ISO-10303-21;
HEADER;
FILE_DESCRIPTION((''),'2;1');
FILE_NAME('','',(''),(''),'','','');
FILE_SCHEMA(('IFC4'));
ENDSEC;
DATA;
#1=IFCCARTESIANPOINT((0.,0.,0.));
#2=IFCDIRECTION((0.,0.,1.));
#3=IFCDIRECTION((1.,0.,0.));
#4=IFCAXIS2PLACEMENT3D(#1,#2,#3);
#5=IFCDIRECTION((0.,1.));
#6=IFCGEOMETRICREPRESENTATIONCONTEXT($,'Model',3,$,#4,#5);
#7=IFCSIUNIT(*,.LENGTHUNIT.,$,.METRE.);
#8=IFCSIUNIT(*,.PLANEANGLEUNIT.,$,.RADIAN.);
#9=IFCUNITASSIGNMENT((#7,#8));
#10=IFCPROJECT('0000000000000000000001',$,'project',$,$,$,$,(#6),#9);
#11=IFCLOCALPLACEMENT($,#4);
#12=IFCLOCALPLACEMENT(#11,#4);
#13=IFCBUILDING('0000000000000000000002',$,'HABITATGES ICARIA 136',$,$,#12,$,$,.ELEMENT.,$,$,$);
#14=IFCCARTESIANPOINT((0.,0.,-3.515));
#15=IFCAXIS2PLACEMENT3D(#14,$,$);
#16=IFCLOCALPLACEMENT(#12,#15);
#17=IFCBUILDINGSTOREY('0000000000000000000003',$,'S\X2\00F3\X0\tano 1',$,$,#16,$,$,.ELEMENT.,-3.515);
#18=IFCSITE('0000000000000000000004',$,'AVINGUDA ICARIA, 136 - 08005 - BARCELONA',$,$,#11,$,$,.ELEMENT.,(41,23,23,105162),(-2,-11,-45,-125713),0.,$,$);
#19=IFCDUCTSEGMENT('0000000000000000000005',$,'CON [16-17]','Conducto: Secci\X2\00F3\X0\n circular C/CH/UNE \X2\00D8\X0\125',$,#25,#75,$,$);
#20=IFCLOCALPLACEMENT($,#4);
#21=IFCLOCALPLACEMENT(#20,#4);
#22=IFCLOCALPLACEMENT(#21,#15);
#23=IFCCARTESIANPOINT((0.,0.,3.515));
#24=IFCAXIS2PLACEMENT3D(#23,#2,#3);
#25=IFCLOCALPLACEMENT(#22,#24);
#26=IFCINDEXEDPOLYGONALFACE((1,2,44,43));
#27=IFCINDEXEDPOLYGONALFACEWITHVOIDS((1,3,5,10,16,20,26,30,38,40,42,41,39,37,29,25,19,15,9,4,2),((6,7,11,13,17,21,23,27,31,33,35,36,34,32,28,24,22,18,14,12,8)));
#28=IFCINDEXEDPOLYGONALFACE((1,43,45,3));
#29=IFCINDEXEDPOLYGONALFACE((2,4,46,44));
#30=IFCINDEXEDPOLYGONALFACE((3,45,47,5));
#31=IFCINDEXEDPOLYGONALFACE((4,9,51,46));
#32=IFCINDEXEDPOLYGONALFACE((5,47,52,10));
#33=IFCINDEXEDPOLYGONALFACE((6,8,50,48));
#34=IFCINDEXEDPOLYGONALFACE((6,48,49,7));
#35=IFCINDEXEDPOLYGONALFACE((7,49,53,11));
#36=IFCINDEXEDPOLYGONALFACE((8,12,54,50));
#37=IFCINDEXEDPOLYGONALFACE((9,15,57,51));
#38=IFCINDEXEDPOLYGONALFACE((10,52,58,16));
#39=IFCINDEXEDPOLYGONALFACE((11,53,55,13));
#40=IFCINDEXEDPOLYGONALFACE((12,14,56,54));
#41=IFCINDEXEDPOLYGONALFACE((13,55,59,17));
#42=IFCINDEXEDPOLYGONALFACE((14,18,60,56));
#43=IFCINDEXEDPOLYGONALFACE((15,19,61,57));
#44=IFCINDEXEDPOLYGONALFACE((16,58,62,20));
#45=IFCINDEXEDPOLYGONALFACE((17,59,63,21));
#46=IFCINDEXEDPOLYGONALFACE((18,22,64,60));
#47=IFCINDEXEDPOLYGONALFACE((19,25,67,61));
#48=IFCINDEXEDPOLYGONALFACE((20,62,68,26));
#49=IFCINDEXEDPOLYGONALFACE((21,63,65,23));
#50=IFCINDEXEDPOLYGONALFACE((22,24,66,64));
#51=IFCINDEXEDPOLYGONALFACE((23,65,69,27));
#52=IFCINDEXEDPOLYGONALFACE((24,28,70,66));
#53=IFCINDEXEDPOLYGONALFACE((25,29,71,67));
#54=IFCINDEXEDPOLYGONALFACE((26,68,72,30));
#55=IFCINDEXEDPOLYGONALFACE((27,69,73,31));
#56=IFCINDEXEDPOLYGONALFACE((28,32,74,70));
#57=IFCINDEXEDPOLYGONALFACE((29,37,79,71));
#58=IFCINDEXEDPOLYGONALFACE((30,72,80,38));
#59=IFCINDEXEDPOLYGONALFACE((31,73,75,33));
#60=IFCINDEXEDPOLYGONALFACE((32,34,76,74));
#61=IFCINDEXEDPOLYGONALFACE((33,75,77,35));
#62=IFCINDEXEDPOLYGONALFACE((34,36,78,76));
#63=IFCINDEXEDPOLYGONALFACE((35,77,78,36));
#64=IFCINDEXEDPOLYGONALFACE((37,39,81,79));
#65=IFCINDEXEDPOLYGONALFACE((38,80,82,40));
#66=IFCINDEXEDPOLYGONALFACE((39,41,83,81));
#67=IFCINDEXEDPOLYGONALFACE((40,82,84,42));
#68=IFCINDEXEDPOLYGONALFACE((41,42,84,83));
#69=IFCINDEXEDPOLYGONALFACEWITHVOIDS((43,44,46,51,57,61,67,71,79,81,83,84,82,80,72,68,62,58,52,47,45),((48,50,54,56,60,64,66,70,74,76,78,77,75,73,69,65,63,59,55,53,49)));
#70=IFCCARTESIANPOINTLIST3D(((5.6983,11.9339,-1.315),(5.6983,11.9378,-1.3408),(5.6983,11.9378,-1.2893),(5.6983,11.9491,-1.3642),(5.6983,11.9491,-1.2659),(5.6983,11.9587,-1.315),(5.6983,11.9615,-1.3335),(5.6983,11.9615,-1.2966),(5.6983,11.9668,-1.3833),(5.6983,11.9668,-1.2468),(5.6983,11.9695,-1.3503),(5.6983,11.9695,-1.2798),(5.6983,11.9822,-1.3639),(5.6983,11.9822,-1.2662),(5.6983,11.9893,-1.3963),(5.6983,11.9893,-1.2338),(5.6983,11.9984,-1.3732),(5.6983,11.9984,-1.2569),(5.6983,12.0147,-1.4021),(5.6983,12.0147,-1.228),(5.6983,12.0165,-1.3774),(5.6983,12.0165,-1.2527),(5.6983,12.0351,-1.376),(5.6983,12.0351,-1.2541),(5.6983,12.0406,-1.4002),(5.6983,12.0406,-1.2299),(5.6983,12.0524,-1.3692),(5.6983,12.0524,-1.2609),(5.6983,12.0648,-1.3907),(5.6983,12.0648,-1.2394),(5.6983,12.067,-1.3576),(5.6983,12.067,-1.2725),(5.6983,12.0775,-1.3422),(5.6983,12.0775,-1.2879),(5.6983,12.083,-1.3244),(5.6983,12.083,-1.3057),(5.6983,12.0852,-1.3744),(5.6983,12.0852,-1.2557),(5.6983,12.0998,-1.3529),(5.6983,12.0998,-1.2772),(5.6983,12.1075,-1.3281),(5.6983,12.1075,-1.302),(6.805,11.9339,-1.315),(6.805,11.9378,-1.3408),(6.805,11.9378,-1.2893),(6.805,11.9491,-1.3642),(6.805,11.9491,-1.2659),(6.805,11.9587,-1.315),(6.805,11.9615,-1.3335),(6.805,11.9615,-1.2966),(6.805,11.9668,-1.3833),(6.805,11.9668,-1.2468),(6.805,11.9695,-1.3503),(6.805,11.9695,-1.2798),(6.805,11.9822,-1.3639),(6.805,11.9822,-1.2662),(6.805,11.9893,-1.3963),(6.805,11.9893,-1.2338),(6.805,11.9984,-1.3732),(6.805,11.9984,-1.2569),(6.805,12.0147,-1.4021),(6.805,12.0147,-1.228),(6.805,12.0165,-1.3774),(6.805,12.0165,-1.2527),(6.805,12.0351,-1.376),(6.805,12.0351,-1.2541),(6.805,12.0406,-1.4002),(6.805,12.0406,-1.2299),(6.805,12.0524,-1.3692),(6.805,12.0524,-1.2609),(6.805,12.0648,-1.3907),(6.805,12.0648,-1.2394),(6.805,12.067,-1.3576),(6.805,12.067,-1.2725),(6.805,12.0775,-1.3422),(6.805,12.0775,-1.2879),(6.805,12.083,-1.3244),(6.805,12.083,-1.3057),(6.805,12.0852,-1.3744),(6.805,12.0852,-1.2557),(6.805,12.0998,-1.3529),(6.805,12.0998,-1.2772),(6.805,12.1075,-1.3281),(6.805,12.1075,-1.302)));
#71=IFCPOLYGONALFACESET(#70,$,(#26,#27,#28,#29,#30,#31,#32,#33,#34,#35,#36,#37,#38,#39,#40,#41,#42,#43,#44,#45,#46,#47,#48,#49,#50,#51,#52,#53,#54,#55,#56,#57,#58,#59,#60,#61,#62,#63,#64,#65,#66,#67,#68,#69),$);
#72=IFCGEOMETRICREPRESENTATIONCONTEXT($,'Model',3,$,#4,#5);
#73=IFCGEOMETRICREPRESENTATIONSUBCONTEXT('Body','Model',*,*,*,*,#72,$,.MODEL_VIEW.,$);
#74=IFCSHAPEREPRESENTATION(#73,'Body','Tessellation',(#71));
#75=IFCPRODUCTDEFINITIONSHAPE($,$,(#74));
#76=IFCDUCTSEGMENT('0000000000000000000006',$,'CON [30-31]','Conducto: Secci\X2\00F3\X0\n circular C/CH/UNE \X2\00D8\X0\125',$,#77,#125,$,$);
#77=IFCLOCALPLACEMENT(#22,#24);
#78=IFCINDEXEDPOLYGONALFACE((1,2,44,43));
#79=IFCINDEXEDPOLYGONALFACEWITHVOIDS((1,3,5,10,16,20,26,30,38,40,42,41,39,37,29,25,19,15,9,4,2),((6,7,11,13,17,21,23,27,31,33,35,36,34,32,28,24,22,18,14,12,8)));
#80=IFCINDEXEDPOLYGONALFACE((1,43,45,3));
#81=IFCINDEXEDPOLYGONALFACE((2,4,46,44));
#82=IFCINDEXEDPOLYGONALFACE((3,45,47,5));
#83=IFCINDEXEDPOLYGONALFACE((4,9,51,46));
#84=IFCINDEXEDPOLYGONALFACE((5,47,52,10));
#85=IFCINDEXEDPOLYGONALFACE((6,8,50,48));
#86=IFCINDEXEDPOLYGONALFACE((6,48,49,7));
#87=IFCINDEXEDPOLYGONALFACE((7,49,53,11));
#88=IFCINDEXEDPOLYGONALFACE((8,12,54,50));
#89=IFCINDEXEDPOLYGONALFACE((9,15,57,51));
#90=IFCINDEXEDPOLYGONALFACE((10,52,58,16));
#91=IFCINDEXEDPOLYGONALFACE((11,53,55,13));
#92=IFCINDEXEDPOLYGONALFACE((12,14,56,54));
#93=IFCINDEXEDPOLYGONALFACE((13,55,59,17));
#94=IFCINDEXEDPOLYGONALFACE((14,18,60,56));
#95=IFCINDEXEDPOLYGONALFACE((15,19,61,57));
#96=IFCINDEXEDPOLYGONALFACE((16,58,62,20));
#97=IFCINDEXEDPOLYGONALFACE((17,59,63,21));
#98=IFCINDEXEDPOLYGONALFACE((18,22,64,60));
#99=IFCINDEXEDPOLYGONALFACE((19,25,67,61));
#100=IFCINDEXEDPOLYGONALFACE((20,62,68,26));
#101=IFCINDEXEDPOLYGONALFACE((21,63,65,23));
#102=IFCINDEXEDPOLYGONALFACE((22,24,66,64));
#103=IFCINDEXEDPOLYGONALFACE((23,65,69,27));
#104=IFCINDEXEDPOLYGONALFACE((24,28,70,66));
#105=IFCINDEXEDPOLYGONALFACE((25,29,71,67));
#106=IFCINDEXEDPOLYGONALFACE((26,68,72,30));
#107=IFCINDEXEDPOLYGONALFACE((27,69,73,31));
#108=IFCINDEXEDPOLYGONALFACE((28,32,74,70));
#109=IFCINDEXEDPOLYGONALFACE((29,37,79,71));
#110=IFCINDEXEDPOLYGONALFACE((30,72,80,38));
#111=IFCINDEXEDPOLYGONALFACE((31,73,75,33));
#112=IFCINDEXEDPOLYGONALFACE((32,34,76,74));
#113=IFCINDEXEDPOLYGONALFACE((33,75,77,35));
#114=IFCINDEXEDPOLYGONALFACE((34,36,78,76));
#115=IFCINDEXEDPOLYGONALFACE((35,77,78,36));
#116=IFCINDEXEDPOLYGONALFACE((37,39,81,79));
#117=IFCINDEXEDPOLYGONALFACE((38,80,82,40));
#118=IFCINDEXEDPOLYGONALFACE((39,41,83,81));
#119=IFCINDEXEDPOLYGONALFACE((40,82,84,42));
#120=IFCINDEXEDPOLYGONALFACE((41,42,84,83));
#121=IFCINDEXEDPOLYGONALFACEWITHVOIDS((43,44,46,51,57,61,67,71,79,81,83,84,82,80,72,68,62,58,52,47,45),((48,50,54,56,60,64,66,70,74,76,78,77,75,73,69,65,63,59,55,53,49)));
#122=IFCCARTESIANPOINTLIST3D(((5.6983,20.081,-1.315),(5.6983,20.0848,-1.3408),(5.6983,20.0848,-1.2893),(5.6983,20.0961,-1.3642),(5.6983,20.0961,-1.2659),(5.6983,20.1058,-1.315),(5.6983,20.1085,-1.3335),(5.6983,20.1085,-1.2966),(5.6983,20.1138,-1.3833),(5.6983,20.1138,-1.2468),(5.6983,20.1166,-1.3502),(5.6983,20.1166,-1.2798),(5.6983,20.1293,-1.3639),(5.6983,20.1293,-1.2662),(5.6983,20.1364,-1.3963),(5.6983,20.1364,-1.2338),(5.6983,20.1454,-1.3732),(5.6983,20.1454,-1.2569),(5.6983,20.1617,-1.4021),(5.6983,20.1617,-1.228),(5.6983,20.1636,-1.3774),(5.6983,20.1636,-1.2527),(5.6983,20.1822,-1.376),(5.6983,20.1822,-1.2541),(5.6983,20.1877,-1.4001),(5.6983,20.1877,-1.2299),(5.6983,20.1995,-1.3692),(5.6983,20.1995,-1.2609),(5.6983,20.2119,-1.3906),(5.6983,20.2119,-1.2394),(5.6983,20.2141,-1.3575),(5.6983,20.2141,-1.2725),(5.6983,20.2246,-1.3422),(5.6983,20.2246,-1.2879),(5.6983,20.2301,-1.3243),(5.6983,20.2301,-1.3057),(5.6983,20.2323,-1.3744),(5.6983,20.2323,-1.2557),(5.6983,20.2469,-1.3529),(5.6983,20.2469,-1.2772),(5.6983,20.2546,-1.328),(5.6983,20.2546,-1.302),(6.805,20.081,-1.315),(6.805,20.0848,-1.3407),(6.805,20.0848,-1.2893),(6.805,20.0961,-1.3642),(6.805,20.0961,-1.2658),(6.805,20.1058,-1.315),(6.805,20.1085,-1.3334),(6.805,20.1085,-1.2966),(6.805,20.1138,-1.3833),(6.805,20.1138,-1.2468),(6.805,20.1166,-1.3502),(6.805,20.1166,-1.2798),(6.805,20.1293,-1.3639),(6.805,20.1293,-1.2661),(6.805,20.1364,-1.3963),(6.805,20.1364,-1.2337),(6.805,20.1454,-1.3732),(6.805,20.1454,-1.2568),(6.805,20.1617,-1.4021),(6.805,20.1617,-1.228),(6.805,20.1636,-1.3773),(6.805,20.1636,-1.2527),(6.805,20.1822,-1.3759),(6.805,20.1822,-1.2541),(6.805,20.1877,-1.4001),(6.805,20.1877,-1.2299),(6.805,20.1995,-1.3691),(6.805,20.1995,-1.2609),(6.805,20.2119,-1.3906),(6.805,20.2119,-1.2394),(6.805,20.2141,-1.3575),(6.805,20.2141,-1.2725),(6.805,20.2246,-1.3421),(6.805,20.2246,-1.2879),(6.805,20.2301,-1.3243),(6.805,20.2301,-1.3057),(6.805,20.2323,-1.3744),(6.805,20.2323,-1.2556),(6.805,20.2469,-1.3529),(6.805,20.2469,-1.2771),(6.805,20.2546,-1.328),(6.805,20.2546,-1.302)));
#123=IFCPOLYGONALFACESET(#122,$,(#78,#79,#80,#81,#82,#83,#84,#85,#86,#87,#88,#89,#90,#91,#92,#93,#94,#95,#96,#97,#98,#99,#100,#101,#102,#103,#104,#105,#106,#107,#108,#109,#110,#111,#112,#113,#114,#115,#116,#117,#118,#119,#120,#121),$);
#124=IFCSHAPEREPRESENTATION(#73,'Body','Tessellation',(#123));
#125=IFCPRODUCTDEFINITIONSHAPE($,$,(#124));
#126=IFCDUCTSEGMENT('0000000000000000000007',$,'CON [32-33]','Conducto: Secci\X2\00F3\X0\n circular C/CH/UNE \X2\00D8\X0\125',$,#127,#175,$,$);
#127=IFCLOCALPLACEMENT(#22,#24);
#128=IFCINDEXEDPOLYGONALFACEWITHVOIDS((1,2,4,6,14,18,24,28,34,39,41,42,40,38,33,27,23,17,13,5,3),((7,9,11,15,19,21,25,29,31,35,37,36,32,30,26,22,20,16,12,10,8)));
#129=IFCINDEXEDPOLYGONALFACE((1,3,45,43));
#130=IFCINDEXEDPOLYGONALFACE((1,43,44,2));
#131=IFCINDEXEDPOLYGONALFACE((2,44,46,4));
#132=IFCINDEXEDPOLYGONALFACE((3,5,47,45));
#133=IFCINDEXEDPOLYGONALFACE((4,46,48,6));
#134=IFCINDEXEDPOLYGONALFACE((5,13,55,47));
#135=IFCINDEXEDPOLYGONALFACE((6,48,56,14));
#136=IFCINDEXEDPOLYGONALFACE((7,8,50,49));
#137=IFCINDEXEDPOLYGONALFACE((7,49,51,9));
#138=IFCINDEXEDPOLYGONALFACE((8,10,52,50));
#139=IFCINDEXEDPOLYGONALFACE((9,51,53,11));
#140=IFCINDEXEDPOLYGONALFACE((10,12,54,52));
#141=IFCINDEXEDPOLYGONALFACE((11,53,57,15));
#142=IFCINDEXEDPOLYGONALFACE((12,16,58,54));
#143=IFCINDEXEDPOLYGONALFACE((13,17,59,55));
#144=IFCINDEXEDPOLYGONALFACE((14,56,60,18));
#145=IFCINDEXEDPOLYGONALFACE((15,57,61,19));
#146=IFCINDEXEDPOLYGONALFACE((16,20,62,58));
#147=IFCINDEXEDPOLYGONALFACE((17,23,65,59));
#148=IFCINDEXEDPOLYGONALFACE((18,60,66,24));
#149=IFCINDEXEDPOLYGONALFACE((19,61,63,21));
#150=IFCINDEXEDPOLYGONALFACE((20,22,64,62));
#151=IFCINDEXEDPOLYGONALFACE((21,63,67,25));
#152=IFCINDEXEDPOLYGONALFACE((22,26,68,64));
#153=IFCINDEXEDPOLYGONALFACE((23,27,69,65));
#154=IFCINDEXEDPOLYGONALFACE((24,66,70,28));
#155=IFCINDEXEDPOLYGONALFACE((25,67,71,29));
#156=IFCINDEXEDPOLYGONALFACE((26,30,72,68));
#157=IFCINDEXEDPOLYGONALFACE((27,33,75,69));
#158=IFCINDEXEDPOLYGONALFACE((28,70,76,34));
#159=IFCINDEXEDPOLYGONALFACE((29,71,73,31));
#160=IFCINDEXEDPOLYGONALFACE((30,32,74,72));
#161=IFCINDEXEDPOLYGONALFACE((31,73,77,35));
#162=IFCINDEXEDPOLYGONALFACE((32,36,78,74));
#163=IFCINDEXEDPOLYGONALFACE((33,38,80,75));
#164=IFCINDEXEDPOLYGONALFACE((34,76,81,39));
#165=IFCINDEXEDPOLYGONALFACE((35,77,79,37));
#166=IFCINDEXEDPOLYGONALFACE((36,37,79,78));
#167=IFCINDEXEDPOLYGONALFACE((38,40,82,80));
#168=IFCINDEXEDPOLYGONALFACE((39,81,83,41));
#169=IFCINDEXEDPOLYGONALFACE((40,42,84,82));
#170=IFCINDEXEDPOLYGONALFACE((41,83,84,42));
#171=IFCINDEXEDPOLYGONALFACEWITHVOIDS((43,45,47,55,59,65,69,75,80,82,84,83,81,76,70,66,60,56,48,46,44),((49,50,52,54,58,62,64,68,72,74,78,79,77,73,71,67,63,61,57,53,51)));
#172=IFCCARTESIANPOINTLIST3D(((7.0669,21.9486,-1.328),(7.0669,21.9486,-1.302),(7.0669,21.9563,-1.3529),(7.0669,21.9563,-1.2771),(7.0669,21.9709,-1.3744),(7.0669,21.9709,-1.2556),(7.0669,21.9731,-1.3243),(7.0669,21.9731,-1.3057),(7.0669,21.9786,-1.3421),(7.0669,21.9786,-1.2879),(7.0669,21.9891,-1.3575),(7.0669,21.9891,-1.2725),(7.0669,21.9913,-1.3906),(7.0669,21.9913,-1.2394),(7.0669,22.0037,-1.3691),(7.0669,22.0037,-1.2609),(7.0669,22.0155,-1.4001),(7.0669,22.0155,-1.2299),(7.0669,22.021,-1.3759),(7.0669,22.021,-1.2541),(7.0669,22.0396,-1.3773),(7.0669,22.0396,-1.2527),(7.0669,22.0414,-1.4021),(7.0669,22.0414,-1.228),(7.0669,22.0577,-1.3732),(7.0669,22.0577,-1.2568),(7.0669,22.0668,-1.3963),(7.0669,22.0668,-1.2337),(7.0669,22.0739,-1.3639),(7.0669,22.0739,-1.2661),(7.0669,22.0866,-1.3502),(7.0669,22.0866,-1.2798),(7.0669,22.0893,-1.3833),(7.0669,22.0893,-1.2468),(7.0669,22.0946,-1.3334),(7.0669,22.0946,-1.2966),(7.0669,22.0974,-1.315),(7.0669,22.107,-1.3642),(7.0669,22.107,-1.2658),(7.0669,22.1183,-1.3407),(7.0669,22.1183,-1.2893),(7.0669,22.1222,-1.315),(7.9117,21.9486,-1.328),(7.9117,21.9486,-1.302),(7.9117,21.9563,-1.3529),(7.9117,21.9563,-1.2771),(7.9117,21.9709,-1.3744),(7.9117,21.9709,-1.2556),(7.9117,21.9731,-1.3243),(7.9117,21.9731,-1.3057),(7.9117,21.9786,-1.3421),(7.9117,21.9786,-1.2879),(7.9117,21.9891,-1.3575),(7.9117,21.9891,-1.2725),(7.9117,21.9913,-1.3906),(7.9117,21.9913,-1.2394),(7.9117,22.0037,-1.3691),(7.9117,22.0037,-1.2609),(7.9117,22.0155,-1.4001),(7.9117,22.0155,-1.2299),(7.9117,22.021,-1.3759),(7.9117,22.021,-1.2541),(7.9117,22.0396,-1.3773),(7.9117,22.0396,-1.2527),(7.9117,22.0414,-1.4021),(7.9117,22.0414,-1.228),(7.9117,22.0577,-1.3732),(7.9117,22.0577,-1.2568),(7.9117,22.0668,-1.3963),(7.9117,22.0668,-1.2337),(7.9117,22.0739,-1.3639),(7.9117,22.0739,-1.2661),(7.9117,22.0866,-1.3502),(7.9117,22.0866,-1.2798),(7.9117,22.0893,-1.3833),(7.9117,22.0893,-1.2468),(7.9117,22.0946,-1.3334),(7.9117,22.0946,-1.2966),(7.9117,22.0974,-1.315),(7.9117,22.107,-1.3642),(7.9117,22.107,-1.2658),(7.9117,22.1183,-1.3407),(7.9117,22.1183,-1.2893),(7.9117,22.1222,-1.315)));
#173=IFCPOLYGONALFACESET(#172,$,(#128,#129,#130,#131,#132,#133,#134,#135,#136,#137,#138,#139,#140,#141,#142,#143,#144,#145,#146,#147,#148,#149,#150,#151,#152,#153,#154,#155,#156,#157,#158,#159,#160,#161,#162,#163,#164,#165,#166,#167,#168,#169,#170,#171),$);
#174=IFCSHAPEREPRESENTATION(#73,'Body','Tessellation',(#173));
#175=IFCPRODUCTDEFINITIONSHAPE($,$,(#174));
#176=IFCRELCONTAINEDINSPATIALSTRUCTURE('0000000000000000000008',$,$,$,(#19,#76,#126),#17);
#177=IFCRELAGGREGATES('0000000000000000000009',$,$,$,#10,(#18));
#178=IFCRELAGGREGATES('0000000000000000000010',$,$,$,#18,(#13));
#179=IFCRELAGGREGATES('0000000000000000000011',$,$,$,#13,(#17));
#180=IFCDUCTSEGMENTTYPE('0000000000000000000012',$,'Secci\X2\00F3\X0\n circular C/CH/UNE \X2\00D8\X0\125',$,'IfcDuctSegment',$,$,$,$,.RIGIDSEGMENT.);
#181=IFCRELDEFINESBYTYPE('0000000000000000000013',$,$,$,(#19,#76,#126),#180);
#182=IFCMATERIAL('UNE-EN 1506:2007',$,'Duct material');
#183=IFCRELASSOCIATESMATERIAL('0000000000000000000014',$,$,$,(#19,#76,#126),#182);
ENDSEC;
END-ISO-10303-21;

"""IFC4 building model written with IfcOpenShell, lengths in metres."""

from ifc_helpers import new_model, si_unit, direction, frame, origin_with_axes, origin_2d_with_axis, place, context, subcontext, project, spatial, hollow_circle, extrude, material, type_object, element, save


model = new_model("IFC4")

# Units and contexts
model_context_1 = context("Model", 3, world=origin_with_axes(), true_north=direction((0.0, 1.0)))
model_context_2 = context("Model", 3, world=origin_with_axes(), true_north=direction((0.0, 1.0)))
body_context_1 = subcontext(model_context_2, "Body", "Model", "MODEL_VIEW")
ifc_project = project(units=[si_unit("LENGTHUNIT", "METRE"), si_unit("PLANEANGLEUNIT", "RADIAN")], contexts=[model_context_1])

# Site, building, storey
site_placement = place(None, origin_with_axes())
site = spatial("IfcSite", under=ifc_project, at=site_placement, Name="AVINGUDA ICARIA, 136 - 08005 - BARCELONA", CompositionType="ELEMENT", RefLatitude=(41, 23, 23, 105162), RefLongitude=(-2, -11, -45, -125713), RefElevation=0.0)
building_placement = place(site_placement, origin_with_axes())
building = spatial("IfcBuilding", under=site, at=building_placement, Name="HABITATGES ICARIA 136", CompositionType="ELEMENT")
storey_placement = place(building_placement, frame((0.0, 0.0, -3.515)))
storey = spatial("IfcBuildingStorey", under=building, at=storey_placement, Name="Sótano 1", CompositionType="ELEMENT", Elevation=-3.515)

# Duct segments
ifc_material_1 = material(Name="UNE-EN 1506:2007", Category="Duct material")
duct_segment_type = type_object("IfcDuctSegmentType", Name="Sección circular C/CH/UNE Ø125", ApplicableOccurrence="IfcDuctSegment", PredefinedType="RIGIDSEGMENT")
placement_1 = place(None, origin_with_axes())
placement_2 = place(placement_1, origin_with_axes())
placement_3 = place(placement_2, frame((0.0, 0.0, -3.515)))
duct_segment_1_placement = place(placement_3, frame((0.0, 0.0, 3.515), z_axis=(0.0, 0.0, 1.0), x_axis=(1.0, 0.0, 0.0)))
element("IfcDuctSegment", 1, at=duct_segment_1_placement, inside=storey, type_object=duct_segment_type, material=ifc_material_1, Name="CON [16-17]", Description="Conducto: Sección circular C/CH/UNE Ø125", context=body_context_1, shape_type="SweptSolid", body=[
    extrude(hollow_circle(Radius=0.0873, WallThickness=0.0248, at=origin_2d_with_axis()), frame((6.805, 12.0212, -1.315), z_axis=(-1.0, 0.0, 0.0), x_axis=(0.0, -1.0, 0.0)), (0.0, 0.0, 1.0), 1.1067),
])
duct_segment_2_placement = place(placement_3, frame((0.0, 0.0, 3.515), z_axis=(0.0, 0.0, 1.0), x_axis=(1.0, 0.0, 0.0)))
element("IfcDuctSegment", 2, at=duct_segment_2_placement, inside=storey, type_object=duct_segment_type, material=ifc_material_1, Name="CON [30-31]", Description="Conducto: Sección circular C/CH/UNE Ø125", context=body_context_1, shape_type="SweptSolid", body=[
    extrude(hollow_circle(Radius=0.0873, WallThickness=0.0248, at=origin_2d_with_axis()), frame((6.805, 20.1683, -1.315), z_axis=(-1.0, 0.0, -0.000017), x_axis=(0.0, -1.0, 0.0)), (0.0, 0.0, 1.0), 1.1067),
])
duct_segment_3_placement = place(placement_3, frame((0.0, 0.0, 3.515), z_axis=(0.0, 0.0, 1.0), x_axis=(1.0, 0.0, 0.0)))
element("IfcDuctSegment", 3, at=duct_segment_3_placement, inside=storey, type_object=duct_segment_type, material=ifc_material_1, Name="CON [32-33]", Description="Conducto: Sección circular C/CH/UNE Ø125", context=body_context_1, shape_type="SweptSolid", body=[
    extrude(hollow_circle(Radius=0.0873, WallThickness=0.0248, at=origin_2d_with_axis()), frame((7.0669, 22.0349, -1.315), z_axis=(1.0, 0.0, 0.0), x_axis=(0.0, 1.0, 0.0)), (0.0, 0.0, 1.0), 0.8448),
])

save(model, "model.ifc")
